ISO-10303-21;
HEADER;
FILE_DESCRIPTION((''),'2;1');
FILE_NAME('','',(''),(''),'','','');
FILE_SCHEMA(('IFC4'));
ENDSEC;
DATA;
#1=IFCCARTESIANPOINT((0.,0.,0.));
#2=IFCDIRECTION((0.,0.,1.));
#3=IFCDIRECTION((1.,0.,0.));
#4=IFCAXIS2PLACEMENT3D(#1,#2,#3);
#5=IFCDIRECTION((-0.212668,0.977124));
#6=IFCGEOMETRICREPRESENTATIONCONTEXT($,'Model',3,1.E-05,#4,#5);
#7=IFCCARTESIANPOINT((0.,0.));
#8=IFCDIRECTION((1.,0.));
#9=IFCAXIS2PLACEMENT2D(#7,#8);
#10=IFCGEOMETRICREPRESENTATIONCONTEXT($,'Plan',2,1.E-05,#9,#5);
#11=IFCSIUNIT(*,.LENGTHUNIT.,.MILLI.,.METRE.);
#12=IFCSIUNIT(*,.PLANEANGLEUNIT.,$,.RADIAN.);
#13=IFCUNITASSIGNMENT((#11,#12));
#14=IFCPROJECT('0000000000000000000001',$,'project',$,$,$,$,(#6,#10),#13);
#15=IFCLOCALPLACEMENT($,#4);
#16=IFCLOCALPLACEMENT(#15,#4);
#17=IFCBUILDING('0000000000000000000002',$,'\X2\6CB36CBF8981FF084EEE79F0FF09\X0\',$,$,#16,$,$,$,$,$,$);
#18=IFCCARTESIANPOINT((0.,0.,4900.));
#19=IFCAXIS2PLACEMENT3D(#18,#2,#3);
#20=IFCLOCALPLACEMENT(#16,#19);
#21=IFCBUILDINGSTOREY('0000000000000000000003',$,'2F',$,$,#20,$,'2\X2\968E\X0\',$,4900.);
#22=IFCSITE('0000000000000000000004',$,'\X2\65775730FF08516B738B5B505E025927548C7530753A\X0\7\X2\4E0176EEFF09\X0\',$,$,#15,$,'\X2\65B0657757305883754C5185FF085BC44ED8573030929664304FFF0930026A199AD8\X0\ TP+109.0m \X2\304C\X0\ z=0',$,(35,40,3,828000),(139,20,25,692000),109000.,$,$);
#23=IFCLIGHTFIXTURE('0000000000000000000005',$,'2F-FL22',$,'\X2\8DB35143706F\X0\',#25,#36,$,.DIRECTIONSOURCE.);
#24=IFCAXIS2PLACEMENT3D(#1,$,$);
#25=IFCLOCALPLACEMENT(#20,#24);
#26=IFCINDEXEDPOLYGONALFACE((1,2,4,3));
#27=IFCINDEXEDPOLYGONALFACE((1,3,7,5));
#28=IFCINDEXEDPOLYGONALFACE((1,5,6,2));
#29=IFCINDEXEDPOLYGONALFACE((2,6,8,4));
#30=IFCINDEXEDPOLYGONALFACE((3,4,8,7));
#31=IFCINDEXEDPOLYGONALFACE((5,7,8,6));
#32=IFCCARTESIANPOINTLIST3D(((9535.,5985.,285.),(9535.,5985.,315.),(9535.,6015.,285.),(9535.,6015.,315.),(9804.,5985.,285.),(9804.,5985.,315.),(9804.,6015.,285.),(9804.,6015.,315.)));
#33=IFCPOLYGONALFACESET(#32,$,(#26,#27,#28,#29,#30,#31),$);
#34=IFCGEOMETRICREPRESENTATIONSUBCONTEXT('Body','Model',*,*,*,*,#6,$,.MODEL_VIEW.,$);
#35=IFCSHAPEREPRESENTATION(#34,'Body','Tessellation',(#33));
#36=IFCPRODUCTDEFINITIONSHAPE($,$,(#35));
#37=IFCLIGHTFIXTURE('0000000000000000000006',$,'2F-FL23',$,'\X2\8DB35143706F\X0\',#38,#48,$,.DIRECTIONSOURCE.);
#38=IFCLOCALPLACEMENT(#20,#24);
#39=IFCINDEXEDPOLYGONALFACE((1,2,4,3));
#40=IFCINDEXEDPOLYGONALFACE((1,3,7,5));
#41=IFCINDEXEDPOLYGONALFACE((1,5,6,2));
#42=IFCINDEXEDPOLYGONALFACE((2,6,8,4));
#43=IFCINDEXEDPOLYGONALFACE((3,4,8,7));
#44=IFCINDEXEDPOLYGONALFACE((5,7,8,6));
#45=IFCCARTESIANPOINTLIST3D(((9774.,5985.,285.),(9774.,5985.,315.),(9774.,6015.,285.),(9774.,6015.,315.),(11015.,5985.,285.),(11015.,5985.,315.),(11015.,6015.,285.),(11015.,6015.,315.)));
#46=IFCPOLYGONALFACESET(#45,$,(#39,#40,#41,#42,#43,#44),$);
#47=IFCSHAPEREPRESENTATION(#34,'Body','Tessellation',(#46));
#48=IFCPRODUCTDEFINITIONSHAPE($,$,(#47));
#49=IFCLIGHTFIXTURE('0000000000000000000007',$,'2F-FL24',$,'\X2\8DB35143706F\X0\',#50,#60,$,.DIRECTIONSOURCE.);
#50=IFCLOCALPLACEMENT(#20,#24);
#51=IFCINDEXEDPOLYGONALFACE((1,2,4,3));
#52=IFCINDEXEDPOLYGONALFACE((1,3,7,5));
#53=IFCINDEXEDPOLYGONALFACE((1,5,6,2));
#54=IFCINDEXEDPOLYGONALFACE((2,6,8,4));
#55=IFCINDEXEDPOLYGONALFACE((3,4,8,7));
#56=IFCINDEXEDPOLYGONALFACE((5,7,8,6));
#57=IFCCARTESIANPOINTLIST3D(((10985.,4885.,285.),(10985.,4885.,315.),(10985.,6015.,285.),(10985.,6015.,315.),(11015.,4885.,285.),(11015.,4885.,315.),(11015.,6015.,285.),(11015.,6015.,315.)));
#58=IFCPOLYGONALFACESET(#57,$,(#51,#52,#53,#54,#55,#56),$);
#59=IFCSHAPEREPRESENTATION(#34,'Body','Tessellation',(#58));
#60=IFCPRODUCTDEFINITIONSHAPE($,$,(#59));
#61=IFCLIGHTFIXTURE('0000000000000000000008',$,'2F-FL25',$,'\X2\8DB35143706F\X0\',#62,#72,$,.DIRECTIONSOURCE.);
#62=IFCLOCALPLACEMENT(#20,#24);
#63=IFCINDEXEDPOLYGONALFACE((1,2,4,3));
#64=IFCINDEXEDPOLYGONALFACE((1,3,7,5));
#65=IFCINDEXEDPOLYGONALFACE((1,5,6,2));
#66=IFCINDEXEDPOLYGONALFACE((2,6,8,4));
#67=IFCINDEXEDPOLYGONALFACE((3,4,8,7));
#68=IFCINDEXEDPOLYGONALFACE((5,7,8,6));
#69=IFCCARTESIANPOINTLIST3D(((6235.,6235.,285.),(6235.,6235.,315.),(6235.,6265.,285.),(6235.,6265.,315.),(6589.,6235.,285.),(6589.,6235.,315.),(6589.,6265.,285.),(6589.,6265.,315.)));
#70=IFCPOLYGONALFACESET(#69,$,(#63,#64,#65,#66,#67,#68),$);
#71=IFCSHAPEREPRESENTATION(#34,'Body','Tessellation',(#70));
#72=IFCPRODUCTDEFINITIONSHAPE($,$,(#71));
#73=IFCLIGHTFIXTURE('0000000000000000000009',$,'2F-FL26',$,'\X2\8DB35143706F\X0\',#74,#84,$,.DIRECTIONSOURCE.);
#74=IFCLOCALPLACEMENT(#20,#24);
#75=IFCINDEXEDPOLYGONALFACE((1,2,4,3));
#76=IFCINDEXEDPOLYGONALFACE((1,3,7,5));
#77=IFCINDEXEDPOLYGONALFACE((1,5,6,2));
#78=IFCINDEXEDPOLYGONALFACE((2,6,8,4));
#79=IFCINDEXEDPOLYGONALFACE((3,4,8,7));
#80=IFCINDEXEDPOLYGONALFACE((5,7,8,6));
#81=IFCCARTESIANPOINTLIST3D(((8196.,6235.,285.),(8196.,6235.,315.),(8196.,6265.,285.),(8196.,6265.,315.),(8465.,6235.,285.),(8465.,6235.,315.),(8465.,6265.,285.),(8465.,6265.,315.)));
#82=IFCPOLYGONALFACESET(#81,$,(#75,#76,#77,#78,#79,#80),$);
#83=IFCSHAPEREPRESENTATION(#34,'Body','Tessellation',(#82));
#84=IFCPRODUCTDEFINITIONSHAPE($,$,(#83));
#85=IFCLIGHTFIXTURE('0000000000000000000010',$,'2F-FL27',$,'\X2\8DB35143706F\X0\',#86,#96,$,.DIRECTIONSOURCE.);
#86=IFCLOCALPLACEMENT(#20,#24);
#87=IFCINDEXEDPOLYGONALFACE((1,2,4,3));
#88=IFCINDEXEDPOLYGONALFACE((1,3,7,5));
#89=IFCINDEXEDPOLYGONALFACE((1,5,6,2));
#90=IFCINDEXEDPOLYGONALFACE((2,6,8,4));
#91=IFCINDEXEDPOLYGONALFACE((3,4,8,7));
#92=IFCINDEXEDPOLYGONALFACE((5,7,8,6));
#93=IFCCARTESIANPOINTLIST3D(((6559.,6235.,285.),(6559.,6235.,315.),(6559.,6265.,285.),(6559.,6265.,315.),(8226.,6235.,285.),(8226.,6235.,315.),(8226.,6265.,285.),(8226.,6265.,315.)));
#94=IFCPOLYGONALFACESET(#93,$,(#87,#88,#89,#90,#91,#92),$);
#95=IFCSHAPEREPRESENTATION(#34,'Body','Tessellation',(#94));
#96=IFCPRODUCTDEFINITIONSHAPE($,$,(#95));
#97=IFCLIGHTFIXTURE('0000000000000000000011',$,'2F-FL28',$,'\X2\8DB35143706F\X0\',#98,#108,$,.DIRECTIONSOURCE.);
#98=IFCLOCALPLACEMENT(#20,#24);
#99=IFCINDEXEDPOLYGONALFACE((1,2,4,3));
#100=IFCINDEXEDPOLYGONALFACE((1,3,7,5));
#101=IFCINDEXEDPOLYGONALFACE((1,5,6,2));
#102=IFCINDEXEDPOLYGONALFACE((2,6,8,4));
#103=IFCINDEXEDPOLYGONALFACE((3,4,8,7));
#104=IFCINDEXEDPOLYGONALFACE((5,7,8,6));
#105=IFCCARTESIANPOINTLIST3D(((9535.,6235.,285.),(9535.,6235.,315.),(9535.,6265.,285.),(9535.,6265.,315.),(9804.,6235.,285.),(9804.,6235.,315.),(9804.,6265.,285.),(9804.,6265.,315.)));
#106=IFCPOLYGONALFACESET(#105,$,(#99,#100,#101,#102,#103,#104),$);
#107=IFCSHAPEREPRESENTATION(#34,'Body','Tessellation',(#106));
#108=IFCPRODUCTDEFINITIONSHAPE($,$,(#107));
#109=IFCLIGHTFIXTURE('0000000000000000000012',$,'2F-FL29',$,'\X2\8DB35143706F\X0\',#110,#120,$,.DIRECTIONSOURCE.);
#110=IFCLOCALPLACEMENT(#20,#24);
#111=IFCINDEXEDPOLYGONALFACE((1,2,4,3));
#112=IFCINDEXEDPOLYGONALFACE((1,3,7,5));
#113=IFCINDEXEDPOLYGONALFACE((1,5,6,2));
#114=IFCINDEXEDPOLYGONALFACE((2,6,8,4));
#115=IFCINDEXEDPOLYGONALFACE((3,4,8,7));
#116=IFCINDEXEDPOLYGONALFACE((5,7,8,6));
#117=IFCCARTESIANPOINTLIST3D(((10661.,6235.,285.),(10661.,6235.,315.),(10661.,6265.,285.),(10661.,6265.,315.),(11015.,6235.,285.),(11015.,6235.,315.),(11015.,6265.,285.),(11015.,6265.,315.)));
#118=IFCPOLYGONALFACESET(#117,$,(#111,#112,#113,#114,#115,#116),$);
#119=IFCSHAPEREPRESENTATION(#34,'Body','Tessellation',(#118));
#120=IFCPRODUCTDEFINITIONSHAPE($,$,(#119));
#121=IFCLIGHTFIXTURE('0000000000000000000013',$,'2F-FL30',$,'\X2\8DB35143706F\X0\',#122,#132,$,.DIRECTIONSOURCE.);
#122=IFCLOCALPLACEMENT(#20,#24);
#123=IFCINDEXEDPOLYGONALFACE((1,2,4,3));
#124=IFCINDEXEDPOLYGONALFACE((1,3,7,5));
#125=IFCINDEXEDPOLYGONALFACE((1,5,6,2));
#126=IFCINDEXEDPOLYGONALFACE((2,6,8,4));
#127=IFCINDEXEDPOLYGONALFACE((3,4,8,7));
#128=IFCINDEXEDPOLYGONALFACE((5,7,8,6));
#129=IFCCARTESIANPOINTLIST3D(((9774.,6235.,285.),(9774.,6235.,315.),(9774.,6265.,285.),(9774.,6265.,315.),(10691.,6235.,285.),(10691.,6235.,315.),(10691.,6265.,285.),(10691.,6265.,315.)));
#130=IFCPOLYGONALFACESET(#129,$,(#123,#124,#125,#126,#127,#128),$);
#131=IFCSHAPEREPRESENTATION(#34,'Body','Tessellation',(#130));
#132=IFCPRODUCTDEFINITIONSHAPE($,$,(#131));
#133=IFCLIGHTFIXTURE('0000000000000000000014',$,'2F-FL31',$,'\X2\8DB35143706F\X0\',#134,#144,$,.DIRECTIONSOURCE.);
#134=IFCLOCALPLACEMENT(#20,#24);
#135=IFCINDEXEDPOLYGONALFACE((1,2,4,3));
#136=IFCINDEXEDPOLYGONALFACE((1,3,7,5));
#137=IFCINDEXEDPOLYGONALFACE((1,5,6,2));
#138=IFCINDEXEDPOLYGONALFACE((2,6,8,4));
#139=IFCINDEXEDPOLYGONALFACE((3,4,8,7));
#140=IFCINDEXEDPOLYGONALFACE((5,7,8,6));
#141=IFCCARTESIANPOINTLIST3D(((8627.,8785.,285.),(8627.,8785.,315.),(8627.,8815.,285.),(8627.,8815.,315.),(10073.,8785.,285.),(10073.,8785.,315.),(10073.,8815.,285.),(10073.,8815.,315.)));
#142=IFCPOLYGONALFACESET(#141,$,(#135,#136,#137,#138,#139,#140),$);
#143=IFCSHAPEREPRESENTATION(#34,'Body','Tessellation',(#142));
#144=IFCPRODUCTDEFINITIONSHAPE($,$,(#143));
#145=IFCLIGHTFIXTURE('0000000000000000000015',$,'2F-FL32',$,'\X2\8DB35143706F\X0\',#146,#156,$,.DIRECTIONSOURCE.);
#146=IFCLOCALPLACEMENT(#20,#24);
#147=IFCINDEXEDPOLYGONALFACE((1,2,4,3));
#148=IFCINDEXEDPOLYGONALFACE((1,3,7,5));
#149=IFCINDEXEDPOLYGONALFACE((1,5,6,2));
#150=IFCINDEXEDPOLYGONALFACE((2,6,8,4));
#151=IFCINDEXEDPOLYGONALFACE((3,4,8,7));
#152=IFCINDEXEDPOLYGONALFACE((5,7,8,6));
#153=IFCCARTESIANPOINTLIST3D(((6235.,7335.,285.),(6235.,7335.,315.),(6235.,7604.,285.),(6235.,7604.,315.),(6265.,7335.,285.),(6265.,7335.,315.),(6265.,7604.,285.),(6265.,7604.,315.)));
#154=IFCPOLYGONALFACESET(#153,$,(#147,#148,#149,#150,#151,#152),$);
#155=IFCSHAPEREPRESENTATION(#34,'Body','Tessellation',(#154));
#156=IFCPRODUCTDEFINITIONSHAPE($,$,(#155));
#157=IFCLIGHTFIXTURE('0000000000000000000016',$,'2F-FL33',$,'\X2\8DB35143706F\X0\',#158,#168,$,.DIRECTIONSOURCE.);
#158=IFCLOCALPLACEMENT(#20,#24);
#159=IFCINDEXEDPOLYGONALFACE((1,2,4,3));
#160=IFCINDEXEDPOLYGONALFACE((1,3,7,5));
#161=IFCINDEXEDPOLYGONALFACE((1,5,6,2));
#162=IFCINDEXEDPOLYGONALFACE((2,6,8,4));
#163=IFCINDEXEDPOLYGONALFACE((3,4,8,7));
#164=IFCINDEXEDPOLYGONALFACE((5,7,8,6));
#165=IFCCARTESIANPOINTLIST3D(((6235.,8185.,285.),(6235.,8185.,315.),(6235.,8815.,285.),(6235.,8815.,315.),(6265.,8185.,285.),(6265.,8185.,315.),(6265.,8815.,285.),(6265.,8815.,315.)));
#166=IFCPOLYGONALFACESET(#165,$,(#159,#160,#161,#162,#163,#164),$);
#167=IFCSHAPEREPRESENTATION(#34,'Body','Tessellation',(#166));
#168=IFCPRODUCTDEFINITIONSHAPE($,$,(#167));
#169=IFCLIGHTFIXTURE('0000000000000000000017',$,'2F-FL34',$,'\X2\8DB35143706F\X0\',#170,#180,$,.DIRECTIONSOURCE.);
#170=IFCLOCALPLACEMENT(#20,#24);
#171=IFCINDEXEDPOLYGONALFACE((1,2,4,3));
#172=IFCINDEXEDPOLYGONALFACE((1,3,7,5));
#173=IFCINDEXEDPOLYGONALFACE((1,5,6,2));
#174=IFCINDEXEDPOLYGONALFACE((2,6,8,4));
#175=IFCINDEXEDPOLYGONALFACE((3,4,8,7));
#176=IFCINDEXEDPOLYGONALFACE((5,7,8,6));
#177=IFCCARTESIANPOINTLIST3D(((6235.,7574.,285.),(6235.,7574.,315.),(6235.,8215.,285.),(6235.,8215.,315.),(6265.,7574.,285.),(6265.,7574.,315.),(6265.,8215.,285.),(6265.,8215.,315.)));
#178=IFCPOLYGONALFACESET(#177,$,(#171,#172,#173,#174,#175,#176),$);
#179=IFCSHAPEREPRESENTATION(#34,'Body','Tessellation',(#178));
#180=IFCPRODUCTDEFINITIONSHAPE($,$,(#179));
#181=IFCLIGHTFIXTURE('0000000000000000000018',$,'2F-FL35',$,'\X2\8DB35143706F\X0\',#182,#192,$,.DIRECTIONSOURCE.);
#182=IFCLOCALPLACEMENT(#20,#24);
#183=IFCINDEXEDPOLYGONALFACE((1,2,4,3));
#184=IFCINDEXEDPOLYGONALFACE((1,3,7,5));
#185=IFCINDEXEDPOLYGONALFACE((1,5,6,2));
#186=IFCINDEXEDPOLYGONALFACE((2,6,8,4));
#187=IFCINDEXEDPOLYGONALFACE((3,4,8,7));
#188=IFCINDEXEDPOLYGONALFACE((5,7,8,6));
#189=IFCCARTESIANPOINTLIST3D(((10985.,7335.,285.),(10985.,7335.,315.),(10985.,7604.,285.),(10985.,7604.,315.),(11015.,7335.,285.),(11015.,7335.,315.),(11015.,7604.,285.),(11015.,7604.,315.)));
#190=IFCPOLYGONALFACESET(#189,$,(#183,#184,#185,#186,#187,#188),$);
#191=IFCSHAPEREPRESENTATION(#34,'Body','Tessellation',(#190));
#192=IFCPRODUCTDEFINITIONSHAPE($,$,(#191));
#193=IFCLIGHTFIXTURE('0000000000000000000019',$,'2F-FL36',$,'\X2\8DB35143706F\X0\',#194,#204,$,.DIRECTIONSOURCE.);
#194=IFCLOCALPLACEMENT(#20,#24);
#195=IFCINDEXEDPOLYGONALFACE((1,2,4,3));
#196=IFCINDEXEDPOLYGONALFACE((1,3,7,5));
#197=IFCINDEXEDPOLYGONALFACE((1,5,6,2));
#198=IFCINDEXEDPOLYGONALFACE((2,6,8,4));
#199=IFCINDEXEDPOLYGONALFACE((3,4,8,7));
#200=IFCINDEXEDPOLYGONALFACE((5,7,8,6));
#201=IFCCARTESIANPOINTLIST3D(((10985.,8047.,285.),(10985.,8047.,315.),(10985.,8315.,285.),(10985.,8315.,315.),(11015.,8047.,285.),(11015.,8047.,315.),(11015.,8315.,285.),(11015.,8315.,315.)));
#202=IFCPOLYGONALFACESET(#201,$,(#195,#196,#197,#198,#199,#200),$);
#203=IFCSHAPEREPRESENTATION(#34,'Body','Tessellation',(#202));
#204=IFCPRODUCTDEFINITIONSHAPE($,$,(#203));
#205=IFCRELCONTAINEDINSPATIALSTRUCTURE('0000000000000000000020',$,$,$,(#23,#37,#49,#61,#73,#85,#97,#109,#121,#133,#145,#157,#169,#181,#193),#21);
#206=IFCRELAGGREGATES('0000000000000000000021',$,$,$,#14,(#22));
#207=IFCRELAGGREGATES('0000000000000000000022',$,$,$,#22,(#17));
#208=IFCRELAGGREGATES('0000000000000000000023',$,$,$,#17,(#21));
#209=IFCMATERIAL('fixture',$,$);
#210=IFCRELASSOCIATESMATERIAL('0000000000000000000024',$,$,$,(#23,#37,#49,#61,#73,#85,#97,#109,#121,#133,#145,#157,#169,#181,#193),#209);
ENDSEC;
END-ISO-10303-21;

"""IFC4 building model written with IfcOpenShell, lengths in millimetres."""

from ifc_helpers import new_model, si_unit, direction, frame, frame_2d, origin_with_axes, origin_2d_with_axis, place, context, subcontext, project, spatial, rectangle, extrude, material, element, save


model = new_model("IFC4")

# Units and contexts
model_context = context("Model", 3, precision=1e-05, world=origin_with_axes(), true_north=direction((-0.212668, 0.977124)))
plan_context = context("Plan", 2, precision=1e-05, world=origin_2d_with_axis(), true_north=direction((-0.212668, 0.977124)))
body_context = subcontext(model_context, "Body", "Model", "MODEL_VIEW")
ifc_project = project(units=[si_unit("LENGTHUNIT", "METRE", prefix="MILLI"), si_unit("PLANEANGLEUNIT", "RADIAN")], contexts=[model_context, plan_context])

# Site, building, storey
site_placement = place(None, origin_with_axes())
site = spatial("IfcSite", under=ifc_project, at=site_placement, Name="敷地（八王子市大和田町7丁目）", LongName="新敷地境界内（寄付地を除く）。標高 TP+109.0m が z=0", RefLatitude=(35, 40, 3, 828000), RefLongitude=(139, 20, 25, 692000), RefElevation=109000.0)
building_placement = place(site_placement, origin_with_axes())
building = spatial("IfcBuilding", under=site, at=building_placement, Name="河沿要（仮称）")
storey_placement = place(building_placement, frame((0.0, 0.0, 4900.0), z_axis=(0.0, 0.0, 1.0), x_axis=(1.0, 0.0, 0.0)))
storey = spatial("IfcBuildingStorey", under=building, at=storey_placement, Name="2F", LongName="2階", Elevation=4900.0)

# Light fixtures
ifc_material = material(Name="fixture")
light_fixture_1_placement = place(storey_placement, origin_with_axes())
element("IfcLightFixture", 1, at=light_fixture_1_placement, inside=storey, material=ifc_material, Name="2F-FL22", ObjectType="足元灯", PredefinedType="DIRECTIONSOURCE", context=body_context, shape_type="SweptSolid", body=[
    extrude(rectangle(XDim=269.0, YDim=30.0, at=frame_2d((9669.5, 6000.0))), frame((0.0, 0.0, 285.0)), (0.0, 0.0, 1.0), 30.0),
])
light_fixture_2_placement = place(storey_placement, origin_with_axes())
element("IfcLightFixture", 2, at=light_fixture_2_placement, inside=storey, material=ifc_material, Name="2F-FL23", ObjectType="足元灯", PredefinedType="DIRECTIONSOURCE", context=body_context, shape_type="SweptSolid", body=[
    extrude(rectangle(XDim=1241.0, YDim=30.0, at=frame_2d((10394.5, 6000.0))), frame((0.0, 0.0, 285.0)), (0.0, 0.0, 1.0), 30.0),
])
light_fixture_3_placement = place(storey_placement, origin_with_axes())
element("IfcLightFixture", 3, at=light_fixture_3_placement, inside=storey, material=ifc_material, Name="2F-FL24", ObjectType="足元灯", PredefinedType="DIRECTIONSOURCE", context=body_context, shape_type="SweptSolid", body=[
    extrude(rectangle(XDim=30.0, YDim=1130.0, at=frame_2d((11000.0, 5450.0))), frame((0.0, 0.0, 285.0)), (0.0, 0.0, 1.0), 30.0),
])
light_fixture_4_placement = place(storey_placement, origin_with_axes())
element("IfcLightFixture", 4, at=light_fixture_4_placement, inside=storey, material=ifc_material, Name="2F-FL25", ObjectType="足元灯", PredefinedType="DIRECTIONSOURCE", context=body_context, shape_type="SweptSolid", body=[
    extrude(rectangle(XDim=354.0, YDim=30.0, at=frame_2d((6412.0, 6250.0))), frame((0.0, 0.0, 285.0)), (0.0, 0.0, 1.0), 30.0),
])
light_fixture_5_placement = place(storey_placement, origin_with_axes())
element("IfcLightFixture", 5, at=light_fixture_5_placement, inside=storey, material=ifc_material, Name="2F-FL26", ObjectType="足元灯", PredefinedType="DIRECTIONSOURCE", context=body_context, shape_type="SweptSolid", body=[
    extrude(rectangle(XDim=269.0, YDim=30.0, at=frame_2d((8330.5, 6250.0))), frame((0.0, 0.0, 285.0)), (0.0, 0.0, 1.0), 30.0),
])
light_fixture_6_placement = place(storey_placement, origin_with_axes())
element("IfcLightFixture", 6, at=light_fixture_6_placement, inside=storey, material=ifc_material, Name="2F-FL27", ObjectType="足元灯", PredefinedType="DIRECTIONSOURCE", context=body_context, shape_type="SweptSolid", body=[
    extrude(rectangle(XDim=1667.0, YDim=30.0, at=frame_2d((7392.5, 6250.0))), frame((0.0, 0.0, 285.0)), (0.0, 0.0, 1.0), 30.0),
])
light_fixture_7_placement = place(storey_placement, origin_with_axes())
element("IfcLightFixture", 7, at=light_fixture_7_placement, inside=storey, material=ifc_material, Name="2F-FL28", ObjectType="足元灯", PredefinedType="DIRECTIONSOURCE", context=body_context, shape_type="SweptSolid", body=[
    extrude(rectangle(XDim=269.0, YDim=30.0, at=frame_2d((9669.5, 6250.0))), frame((0.0, 0.0, 285.0)), (0.0, 0.0, 1.0), 30.0),
])
light_fixture_8_placement = place(storey_placement, origin_with_axes())
element("IfcLightFixture", 8, at=light_fixture_8_placement, inside=storey, material=ifc_material, Name="2F-FL29", ObjectType="足元灯", PredefinedType="DIRECTIONSOURCE", context=body_context, shape_type="SweptSolid", body=[
    extrude(rectangle(XDim=354.0, YDim=30.0, at=frame_2d((10838.0, 6250.0))), frame((0.0, 0.0, 285.0)), (0.0, 0.0, 1.0), 30.0),
])
light_fixture_9_placement = place(storey_placement, origin_with_axes())
element("IfcLightFixture", 9, at=light_fixture_9_placement, inside=storey, material=ifc_material, Name="2F-FL30", ObjectType="足元灯", PredefinedType="DIRECTIONSOURCE", context=body_context, shape_type="SweptSolid", body=[
    extrude(rectangle(XDim=917.0, YDim=30.0, at=frame_2d((10232.5, 6250.0))), frame((0.0, 0.0, 285.0)), (0.0, 0.0, 1.0), 30.0),
])
light_fixture_10_placement = place(storey_placement, origin_with_axes())
element("IfcLightFixture", 10, at=light_fixture_10_placement, inside=storey, material=ifc_material, Name="2F-FL31", ObjectType="足元灯", PredefinedType="DIRECTIONSOURCE", context=body_context, shape_type="SweptSolid", body=[
    extrude(rectangle(XDim=1446.0, YDim=30.0, at=frame_2d((9350.0, 8800.0))), frame((0.0, 0.0, 285.0)), (0.0, 0.0, 1.0), 30.0),
])
light_fixture_11_placement = place(storey_placement, origin_with_axes())
element("IfcLightFixture", 11, at=light_fixture_11_placement, inside=storey, material=ifc_material, Name="2F-FL32", ObjectType="足元灯", PredefinedType="DIRECTIONSOURCE", context=body_context, shape_type="SweptSolid", body=[
    extrude(rectangle(XDim=30.0, YDim=269.0, at=frame_2d((6250.0, 7469.5))), frame((0.0, 0.0, 285.0)), (0.0, 0.0, 1.0), 30.0),
])
light_fixture_12_placement = place(storey_placement, origin_with_axes())
element("IfcLightFixture", 12, at=light_fixture_12_placement, inside=storey, material=ifc_material, Name="2F-FL33", ObjectType="足元灯", PredefinedType="DIRECTIONSOURCE", context=body_context, shape_type="SweptSolid", body=[
    extrude(rectangle(XDim=30.0, YDim=630.0, at=frame_2d((6250.0, 8500.0))), frame((0.0, 0.0, 285.0)), (0.0, 0.0, 1.0), 30.0),
])
light_fixture_13_placement = place(storey_placement, origin_with_axes())
element("IfcLightFixture", 13, at=light_fixture_13_placement, inside=storey, material=ifc_material, Name="2F-FL34", ObjectType="足元灯", PredefinedType="DIRECTIONSOURCE", context=body_context, shape_type="SweptSolid", body=[
    extrude(rectangle(XDim=30.0, YDim=641.0, at=frame_2d((6250.0, 7894.5))), frame((0.0, 0.0, 285.0)), (0.0, 0.0, 1.0), 30.0),
])
light_fixture_14_placement = place(storey_placement, origin_with_axes())
element("IfcLightFixture", 14, at=light_fixture_14_placement, inside=storey, material=ifc_material, Name="2F-FL35", ObjectType="足元灯", PredefinedType="DIRECTIONSOURCE", context=body_context, shape_type="SweptSolid", body=[
    extrude(rectangle(XDim=30.0, YDim=269.0, at=frame_2d((11000.0, 7469.5))), frame((0.0, 0.0, 285.0)), (0.0, 0.0, 1.0), 30.0),
])
light_fixture_15_placement = place(storey_placement, origin_with_axes())
element("IfcLightFixture", 15, at=light_fixture_15_placement, inside=storey, material=ifc_material, Name="2F-FL36", ObjectType="足元灯", PredefinedType="DIRECTIONSOURCE", context=body_context, shape_type="SweptSolid", body=[
    extrude(rectangle(XDim=30.0, YDim=268.0, at=frame_2d((11000.0, 8181.0))), frame((0.0, 0.0, 285.0)), (0.0, 0.0, 1.0), 30.0),
])

save(model, "model.ifc")
